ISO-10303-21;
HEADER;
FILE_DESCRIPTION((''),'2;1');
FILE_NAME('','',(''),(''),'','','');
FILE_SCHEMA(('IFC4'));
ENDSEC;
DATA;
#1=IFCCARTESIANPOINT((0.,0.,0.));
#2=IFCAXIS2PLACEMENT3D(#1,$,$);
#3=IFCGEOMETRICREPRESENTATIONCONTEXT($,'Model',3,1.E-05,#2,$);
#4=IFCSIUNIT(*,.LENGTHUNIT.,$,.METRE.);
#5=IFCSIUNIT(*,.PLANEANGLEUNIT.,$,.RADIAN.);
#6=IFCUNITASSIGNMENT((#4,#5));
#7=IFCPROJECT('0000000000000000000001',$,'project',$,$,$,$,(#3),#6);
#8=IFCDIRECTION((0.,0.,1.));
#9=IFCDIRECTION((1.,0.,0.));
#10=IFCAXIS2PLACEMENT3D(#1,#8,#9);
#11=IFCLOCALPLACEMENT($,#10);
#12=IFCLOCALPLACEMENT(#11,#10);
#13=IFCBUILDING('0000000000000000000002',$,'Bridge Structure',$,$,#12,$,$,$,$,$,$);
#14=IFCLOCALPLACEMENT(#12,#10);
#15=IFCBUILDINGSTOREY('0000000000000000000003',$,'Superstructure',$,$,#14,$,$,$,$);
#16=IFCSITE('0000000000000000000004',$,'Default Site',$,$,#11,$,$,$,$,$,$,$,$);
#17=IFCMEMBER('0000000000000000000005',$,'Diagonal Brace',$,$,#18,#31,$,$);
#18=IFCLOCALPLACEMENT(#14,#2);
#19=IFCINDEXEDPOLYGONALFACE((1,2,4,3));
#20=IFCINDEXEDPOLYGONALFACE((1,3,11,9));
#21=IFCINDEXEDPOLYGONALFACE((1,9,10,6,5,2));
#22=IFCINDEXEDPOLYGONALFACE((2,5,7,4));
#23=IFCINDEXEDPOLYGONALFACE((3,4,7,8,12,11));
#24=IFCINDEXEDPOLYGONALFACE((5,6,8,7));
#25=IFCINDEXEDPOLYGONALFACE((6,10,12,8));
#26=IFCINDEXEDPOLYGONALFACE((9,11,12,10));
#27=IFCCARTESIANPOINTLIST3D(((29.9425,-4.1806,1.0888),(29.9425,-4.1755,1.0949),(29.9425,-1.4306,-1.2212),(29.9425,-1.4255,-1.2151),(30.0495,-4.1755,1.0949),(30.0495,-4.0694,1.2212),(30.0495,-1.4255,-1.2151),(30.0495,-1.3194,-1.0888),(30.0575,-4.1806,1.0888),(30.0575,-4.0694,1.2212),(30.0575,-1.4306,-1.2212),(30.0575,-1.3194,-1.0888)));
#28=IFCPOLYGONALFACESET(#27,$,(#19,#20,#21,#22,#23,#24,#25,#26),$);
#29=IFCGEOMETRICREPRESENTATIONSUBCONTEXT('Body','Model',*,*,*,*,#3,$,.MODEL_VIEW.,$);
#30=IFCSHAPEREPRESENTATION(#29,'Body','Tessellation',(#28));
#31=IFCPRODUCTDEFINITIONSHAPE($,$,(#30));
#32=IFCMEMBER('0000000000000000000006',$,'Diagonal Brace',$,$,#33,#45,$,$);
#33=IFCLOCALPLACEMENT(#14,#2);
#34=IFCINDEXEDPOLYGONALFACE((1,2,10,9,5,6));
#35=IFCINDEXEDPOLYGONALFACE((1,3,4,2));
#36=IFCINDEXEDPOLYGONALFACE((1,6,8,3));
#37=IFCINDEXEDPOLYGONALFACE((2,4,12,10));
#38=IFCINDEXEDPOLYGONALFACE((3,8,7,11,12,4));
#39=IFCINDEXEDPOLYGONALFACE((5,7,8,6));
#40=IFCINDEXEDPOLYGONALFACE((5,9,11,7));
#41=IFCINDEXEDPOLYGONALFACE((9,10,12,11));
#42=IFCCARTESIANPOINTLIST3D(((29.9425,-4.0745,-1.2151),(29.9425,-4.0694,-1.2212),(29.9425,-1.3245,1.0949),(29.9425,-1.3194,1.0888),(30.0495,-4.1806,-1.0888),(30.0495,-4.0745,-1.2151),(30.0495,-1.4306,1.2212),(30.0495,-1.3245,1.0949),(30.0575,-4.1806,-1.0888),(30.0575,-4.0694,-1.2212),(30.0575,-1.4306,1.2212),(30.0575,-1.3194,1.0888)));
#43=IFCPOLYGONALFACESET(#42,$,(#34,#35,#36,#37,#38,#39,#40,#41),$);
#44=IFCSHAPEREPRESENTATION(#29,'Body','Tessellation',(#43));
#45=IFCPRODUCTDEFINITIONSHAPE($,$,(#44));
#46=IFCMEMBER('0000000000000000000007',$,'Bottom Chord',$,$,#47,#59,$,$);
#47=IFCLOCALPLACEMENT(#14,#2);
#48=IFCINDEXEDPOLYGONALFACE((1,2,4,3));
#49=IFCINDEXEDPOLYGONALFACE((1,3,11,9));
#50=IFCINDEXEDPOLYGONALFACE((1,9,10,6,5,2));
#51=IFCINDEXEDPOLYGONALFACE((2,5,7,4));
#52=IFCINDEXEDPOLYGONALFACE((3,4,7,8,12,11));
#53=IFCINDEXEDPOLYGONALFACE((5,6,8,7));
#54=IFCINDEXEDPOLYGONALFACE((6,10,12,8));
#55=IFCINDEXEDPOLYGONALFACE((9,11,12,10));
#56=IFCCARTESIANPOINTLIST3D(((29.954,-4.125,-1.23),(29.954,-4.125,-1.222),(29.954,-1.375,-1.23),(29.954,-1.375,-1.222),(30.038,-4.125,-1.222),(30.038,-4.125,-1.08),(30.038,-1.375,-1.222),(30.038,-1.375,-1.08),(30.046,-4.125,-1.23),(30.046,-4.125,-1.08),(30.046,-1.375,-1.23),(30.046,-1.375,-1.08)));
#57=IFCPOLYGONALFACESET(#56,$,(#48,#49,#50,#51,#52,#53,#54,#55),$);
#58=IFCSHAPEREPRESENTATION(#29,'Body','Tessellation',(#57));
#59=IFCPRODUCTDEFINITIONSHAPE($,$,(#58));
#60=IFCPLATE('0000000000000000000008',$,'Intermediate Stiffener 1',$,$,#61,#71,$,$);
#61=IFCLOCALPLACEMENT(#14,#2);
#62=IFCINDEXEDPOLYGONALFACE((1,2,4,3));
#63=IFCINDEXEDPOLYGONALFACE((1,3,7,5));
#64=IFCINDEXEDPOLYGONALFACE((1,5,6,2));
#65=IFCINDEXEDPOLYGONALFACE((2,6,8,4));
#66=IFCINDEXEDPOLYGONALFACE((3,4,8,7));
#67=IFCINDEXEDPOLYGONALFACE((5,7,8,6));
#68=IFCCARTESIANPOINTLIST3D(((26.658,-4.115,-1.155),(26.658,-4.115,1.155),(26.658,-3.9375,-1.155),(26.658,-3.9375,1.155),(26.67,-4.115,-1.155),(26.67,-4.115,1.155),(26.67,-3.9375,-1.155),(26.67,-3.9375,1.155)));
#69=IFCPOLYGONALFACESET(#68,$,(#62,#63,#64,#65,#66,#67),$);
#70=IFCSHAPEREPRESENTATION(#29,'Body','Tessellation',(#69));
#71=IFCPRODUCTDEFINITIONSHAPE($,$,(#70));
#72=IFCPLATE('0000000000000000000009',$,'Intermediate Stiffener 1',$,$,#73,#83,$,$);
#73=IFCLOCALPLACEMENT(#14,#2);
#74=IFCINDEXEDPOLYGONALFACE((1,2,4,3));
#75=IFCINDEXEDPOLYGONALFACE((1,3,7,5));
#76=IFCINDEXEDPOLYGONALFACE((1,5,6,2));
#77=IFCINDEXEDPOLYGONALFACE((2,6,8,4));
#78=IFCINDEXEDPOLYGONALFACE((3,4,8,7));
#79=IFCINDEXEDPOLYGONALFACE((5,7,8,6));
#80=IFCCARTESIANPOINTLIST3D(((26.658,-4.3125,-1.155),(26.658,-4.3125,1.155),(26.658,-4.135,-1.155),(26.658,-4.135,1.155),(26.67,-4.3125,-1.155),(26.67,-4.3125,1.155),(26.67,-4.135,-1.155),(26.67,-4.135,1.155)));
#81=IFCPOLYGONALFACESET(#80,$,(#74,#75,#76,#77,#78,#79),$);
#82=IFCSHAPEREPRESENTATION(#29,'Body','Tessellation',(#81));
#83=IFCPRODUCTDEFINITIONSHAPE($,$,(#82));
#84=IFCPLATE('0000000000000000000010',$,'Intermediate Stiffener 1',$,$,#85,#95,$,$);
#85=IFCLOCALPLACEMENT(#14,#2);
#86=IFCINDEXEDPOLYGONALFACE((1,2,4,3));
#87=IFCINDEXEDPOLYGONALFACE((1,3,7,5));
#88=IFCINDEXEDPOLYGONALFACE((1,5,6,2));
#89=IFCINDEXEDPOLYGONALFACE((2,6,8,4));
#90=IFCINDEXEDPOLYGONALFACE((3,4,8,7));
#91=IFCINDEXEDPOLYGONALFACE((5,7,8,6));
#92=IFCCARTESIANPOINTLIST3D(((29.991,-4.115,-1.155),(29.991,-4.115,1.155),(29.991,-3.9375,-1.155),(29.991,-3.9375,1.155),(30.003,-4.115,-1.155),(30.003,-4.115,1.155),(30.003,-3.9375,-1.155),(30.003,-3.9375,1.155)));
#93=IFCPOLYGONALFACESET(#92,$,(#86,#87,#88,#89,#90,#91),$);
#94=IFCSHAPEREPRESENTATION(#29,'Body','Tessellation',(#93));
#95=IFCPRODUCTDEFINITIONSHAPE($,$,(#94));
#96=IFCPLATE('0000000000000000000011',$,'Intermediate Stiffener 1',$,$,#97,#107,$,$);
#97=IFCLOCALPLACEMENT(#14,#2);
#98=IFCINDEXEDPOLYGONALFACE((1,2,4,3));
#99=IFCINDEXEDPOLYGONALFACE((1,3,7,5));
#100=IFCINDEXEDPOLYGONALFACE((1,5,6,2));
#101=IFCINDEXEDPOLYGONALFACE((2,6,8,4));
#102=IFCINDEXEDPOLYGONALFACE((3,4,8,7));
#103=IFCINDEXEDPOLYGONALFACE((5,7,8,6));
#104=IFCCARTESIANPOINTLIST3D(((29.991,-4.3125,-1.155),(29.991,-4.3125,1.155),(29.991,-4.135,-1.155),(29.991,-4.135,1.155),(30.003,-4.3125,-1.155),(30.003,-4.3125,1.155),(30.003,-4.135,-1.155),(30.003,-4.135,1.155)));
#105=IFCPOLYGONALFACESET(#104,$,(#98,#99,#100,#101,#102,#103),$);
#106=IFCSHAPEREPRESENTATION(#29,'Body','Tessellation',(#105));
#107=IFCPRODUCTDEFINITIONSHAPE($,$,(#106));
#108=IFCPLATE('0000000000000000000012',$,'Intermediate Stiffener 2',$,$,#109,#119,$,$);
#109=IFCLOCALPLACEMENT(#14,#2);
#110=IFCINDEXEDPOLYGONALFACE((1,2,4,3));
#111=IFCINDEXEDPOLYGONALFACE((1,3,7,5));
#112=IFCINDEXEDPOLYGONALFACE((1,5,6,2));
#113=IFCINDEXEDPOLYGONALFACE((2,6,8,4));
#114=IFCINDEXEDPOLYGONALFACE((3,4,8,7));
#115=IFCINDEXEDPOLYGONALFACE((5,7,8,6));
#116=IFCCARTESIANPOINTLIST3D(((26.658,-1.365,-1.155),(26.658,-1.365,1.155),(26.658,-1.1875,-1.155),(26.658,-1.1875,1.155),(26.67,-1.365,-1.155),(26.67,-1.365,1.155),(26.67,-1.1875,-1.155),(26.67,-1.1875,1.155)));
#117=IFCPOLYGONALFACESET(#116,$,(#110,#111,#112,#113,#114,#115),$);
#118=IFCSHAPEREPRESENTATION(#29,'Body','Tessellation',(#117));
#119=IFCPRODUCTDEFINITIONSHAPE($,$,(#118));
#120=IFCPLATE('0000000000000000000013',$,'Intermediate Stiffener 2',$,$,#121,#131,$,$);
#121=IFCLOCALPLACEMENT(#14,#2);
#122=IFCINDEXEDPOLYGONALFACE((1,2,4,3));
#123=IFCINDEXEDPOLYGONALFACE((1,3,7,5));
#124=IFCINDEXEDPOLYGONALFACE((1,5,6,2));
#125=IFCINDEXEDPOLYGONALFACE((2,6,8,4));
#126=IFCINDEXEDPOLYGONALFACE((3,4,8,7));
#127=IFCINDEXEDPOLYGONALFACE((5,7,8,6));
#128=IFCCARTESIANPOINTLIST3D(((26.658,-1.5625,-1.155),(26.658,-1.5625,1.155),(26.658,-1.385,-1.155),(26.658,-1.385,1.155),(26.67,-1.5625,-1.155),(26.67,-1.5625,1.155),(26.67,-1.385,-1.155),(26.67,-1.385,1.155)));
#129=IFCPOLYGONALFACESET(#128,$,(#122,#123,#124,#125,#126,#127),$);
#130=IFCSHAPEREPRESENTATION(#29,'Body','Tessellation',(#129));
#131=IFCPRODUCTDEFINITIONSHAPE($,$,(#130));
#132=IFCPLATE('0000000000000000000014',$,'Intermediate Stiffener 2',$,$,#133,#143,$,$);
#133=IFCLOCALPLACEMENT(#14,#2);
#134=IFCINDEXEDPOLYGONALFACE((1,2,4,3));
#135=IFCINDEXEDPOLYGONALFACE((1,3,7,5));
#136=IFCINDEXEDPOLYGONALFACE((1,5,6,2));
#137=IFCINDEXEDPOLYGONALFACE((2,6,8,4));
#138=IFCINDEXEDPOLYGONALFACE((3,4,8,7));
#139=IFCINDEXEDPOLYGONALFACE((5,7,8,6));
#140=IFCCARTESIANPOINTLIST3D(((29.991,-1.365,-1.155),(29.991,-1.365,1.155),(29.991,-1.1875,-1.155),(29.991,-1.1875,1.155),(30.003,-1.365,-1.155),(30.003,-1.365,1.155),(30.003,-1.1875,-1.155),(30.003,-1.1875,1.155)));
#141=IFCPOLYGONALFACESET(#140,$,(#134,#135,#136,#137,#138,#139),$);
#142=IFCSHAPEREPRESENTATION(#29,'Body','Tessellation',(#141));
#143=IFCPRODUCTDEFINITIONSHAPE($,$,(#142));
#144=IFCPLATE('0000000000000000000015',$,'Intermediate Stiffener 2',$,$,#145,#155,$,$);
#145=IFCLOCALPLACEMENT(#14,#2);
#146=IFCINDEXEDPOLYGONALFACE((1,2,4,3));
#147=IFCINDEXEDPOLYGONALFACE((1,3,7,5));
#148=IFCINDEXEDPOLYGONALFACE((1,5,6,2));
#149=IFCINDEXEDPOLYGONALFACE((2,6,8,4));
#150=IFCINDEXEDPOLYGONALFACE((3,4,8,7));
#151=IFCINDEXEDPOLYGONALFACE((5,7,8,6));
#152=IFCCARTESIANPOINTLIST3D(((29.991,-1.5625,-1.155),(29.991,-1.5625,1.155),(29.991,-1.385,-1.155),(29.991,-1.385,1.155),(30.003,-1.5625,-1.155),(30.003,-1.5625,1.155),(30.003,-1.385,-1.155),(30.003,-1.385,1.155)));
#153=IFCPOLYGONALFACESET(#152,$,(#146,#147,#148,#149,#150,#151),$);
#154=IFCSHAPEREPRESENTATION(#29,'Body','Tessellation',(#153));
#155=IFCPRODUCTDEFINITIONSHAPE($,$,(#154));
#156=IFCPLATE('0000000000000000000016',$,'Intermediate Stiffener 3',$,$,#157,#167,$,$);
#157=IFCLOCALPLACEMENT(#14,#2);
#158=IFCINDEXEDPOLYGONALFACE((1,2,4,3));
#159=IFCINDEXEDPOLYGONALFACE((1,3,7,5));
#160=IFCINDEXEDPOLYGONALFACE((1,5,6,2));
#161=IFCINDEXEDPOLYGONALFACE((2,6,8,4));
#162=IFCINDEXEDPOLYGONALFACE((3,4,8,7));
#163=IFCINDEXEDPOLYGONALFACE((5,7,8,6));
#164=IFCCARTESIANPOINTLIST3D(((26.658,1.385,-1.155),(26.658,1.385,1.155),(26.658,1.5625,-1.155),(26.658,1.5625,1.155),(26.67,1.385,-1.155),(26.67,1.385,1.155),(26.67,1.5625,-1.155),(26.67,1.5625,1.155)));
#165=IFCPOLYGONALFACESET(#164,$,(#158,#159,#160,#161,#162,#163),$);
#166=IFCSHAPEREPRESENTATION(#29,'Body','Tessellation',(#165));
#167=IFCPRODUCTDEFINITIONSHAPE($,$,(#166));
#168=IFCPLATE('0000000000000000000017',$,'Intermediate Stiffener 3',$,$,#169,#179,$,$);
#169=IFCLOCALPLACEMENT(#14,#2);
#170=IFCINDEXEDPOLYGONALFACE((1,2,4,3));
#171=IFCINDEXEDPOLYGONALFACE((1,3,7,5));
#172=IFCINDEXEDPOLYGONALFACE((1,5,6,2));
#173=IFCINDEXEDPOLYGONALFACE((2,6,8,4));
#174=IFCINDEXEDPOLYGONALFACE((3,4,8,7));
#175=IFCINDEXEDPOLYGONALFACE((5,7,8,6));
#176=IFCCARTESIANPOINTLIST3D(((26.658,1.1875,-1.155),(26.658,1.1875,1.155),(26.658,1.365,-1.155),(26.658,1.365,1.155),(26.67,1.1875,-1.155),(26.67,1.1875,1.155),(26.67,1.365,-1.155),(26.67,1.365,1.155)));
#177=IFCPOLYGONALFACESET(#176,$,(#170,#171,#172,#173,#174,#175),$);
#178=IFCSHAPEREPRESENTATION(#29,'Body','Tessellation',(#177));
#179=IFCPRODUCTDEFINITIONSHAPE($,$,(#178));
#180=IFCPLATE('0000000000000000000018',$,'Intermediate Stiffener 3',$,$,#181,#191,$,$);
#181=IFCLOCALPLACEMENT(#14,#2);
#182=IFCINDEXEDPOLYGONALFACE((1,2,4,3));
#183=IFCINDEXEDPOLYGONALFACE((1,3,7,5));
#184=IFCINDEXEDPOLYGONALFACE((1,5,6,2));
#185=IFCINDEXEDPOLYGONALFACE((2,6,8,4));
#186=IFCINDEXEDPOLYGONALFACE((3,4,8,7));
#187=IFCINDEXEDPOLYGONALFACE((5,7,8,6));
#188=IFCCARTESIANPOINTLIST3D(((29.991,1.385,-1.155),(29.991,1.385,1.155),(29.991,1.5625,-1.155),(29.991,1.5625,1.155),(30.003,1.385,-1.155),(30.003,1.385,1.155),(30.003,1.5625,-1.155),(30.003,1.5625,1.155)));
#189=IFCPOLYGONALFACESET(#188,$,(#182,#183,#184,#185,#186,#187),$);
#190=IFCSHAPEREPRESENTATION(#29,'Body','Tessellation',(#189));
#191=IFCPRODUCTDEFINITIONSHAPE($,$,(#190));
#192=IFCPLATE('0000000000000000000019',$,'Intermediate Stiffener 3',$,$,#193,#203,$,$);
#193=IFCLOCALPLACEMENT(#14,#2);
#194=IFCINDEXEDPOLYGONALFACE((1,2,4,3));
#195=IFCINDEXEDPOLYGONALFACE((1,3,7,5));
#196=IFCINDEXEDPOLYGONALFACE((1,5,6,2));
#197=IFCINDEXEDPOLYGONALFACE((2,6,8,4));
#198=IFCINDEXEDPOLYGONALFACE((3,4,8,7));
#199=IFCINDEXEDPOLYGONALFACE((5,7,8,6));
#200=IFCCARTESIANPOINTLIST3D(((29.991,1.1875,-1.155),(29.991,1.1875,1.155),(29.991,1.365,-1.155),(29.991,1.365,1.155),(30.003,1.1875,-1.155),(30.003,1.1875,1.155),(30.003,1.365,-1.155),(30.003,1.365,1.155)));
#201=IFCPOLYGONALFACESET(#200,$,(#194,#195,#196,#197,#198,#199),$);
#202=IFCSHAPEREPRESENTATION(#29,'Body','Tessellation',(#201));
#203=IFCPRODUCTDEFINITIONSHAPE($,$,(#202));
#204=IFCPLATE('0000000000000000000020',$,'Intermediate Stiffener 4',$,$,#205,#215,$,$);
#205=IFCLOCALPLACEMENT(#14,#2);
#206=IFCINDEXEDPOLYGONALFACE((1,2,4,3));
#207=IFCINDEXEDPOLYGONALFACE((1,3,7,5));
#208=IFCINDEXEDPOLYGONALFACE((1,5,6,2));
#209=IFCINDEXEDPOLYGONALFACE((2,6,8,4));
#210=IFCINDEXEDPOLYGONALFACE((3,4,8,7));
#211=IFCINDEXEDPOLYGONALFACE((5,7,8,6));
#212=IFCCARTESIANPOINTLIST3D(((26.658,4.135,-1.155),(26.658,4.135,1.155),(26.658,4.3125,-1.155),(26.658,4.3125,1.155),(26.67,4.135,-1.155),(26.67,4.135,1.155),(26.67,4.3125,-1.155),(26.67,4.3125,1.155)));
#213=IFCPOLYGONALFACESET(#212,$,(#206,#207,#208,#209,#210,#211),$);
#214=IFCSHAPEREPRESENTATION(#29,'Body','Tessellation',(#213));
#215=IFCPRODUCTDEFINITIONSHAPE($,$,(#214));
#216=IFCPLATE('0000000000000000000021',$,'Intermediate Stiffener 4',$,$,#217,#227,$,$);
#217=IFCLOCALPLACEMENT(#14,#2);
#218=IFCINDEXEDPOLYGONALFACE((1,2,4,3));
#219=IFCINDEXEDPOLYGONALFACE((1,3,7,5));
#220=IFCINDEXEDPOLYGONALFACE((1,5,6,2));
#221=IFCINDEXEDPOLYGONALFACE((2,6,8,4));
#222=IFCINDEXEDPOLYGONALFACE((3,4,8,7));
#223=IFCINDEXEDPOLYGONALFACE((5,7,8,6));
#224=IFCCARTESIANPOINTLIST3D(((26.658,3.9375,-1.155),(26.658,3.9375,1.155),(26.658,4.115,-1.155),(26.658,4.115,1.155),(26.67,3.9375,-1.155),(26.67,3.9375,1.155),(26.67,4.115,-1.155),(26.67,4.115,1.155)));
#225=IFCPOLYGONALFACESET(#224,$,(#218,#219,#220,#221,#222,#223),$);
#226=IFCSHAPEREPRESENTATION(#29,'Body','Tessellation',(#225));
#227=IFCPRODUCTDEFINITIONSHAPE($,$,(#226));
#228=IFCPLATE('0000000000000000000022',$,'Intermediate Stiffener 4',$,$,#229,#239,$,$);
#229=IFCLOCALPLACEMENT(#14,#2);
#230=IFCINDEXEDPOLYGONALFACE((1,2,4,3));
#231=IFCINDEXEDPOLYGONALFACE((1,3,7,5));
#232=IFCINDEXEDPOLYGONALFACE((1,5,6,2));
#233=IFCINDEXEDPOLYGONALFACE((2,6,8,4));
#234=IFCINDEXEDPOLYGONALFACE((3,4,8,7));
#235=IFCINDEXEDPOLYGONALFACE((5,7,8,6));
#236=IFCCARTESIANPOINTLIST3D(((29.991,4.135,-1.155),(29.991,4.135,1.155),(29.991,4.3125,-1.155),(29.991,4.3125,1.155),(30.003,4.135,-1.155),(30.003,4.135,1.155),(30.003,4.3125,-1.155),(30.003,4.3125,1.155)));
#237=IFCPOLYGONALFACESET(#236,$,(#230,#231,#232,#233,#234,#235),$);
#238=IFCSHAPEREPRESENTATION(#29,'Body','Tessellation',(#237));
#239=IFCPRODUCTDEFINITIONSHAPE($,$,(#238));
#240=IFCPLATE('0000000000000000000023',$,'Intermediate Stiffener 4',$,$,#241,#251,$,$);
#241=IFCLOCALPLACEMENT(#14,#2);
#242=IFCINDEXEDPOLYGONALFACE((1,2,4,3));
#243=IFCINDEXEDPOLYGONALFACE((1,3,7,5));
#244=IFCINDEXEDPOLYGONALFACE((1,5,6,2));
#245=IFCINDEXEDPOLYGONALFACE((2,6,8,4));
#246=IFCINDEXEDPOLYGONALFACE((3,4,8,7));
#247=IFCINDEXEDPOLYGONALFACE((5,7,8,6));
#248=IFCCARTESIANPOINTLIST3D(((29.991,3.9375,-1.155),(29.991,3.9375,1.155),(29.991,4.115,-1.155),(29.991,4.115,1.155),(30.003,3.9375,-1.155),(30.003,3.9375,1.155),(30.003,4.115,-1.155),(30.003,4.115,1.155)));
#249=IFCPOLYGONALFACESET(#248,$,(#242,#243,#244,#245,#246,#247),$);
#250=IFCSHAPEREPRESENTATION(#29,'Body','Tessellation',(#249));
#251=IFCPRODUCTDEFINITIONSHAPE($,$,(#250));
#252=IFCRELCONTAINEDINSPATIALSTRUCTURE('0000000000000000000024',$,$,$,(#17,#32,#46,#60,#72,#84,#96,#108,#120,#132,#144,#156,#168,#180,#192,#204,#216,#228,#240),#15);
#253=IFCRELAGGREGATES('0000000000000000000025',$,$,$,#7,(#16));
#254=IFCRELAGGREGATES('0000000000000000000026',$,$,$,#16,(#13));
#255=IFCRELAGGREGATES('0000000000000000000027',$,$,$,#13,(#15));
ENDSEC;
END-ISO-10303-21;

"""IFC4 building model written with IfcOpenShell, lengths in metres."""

from ifc_helpers import new_model, si_unit, frame, origin, origin_with_axes, origin_2d_with_axis, place, context, subcontext, project, spatial, rectangle, l_section, extrude, element, save


model = new_model("IFC4")

# Units and contexts
model_context = context("Model", 3, precision=1e-05, world=origin())
body_context = subcontext(model_context, "Body", "Model", "MODEL_VIEW")
ifc_project = project(units=[si_unit("LENGTHUNIT", "METRE"), si_unit("PLANEANGLEUNIT", "RADIAN")], contexts=[model_context])

# Site, building, storey
site_placement = place(None, origin_with_axes())
site = spatial("IfcSite", under=ifc_project, at=site_placement, Name="Default Site")
building_placement = place(site_placement, origin_with_axes())
building = spatial("IfcBuilding", under=site, at=building_placement, Name="Bridge Structure")
storey_placement = place(building_placement, origin_with_axes())
storey = spatial("IfcBuildingStorey", under=building, at=storey_placement, Name="Superstructure")

# Members
for number, where, z_axis, x_axis, name in (
    (1, (30.0, -4.125, 1.155), (0.0, 0.765705, -0.643192), (-1.0, 0.0, 0.0), "Diagonal Brace"),
    (2, (30.0, -4.125, -1.155), (0.0, 0.765705, 0.643192), (-1.0, 0.0, 0.0), "Diagonal Brace"),
):
    element("IfcMember", number, at=place(storey_placement, frame(where, z_axis=z_axis, x_axis=x_axis)), inside=storey, Name=name, context=body_context, shape_type="SweptSolid", body=[
        extrude(l_section(Depth=0.173, Width=0.115, Thickness=0.008, at=origin_2d_with_axis()), origin_with_axes(), (0.0, 0.0, 1.0), 3.5915),
    ])
member_1_placement = place(storey_placement, frame((30.0, -4.125, -1.155), z_axis=(0.0, 1.0, 0.0), x_axis=(-1.0, 0.0, 0.0)))
element("IfcMember", 3, at=member_1_placement, inside=storey, Name="Bottom Chord", context=body_context, shape_type="SweptSolid", body=[
    extrude(l_section(Depth=0.15, Width=0.092, Thickness=0.008, at=origin_2d_with_axis()), origin_with_axes(), (0.0, 0.0, 1.0), 2.75),
])

# Plates
for number, where, z_axis, x_axis, name in (
    (4, (26.664, -4.0263, -1.155), (0.0, 0.0, 1.0), (1.0, 0.0, 0.0), "Intermediate Stiffener 1"),
    (5, (26.664, -4.2237, -1.155), (0.0, 0.0, 1.0), (1.0, 0.0, 0.0), "Intermediate Stiffener 1"),
    (6, (29.997, -4.0263, -1.155), (0.0, 0.0, 1.0), (1.0, 0.0, 0.0), "Intermediate Stiffener 1"),
    (7, (29.997, -4.2237, -1.155), (0.0, 0.0, 1.0), (1.0, 0.0, 0.0), "Intermediate Stiffener 1"),
    (8, (26.664, -1.2763, -1.155), (0.0, 0.0, 1.0), (1.0, 0.0, 0.0), "Intermediate Stiffener 2"),
    (9, (26.664, -1.4738, -1.155), (0.0, 0.0, 1.0), (1.0, 0.0, 0.0), "Intermediate Stiffener 2"),
    (10, (29.997, -1.2763, -1.155), (0.0, 0.0, 1.0), (1.0, 0.0, 0.0), "Intermediate Stiffener 2"),
    (11, (29.997, -1.4738, -1.155), (0.0, 0.0, 1.0), (1.0, 0.0, 0.0), "Intermediate Stiffener 2"),
    (12, (26.664, 1.4738, -1.155), (0.0, 0.0, 1.0), (1.0, 0.0, 0.0), "Intermediate Stiffener 3"),
    (13, (26.664, 1.2763, -1.155), (0.0, 0.0, 1.0), (1.0, 0.0, 0.0), "Intermediate Stiffener 3"),
    (14, (29.997, 1.4738, -1.155), (0.0, 0.0, 1.0), (1.0, 0.0, 0.0), "Intermediate Stiffener 3"),
    (15, (29.997, 1.2763, -1.155), (0.0, 0.0, 1.0), (1.0, 0.0, 0.0), "Intermediate Stiffener 3"),
    (16, (26.664, 4.2237, -1.155), (0.0, 0.0, 1.0), (1.0, 0.0, 0.0), "Intermediate Stiffener 4"),
    (17, (26.664, 4.0263, -1.155), (0.0, 0.0, 1.0), (1.0, 0.0, 0.0), "Intermediate Stiffener 4"),
    (18, (29.997, 4.2237, -1.155), (0.0, 0.0, 1.0), (1.0, 0.0, 0.0), "Intermediate Stiffener 4"),
    (19, (29.997, 4.0263, -1.155), (0.0, 0.0, 1.0), (1.0, 0.0, 0.0), "Intermediate Stiffener 4"),
):
    element("IfcPlate", number, at=place(storey_placement, frame(where, z_axis=z_axis, x_axis=x_axis)), inside=storey, Name=name, context=body_context, shape_type="SweptSolid", body=[
        extrude(rectangle(XDim=0.012, YDim=0.1775, at=origin_2d_with_axis()), origin_with_axes(), (0.0, 0.0, 1.0), 2.31),
    ])

save(model, "model.ifc")
